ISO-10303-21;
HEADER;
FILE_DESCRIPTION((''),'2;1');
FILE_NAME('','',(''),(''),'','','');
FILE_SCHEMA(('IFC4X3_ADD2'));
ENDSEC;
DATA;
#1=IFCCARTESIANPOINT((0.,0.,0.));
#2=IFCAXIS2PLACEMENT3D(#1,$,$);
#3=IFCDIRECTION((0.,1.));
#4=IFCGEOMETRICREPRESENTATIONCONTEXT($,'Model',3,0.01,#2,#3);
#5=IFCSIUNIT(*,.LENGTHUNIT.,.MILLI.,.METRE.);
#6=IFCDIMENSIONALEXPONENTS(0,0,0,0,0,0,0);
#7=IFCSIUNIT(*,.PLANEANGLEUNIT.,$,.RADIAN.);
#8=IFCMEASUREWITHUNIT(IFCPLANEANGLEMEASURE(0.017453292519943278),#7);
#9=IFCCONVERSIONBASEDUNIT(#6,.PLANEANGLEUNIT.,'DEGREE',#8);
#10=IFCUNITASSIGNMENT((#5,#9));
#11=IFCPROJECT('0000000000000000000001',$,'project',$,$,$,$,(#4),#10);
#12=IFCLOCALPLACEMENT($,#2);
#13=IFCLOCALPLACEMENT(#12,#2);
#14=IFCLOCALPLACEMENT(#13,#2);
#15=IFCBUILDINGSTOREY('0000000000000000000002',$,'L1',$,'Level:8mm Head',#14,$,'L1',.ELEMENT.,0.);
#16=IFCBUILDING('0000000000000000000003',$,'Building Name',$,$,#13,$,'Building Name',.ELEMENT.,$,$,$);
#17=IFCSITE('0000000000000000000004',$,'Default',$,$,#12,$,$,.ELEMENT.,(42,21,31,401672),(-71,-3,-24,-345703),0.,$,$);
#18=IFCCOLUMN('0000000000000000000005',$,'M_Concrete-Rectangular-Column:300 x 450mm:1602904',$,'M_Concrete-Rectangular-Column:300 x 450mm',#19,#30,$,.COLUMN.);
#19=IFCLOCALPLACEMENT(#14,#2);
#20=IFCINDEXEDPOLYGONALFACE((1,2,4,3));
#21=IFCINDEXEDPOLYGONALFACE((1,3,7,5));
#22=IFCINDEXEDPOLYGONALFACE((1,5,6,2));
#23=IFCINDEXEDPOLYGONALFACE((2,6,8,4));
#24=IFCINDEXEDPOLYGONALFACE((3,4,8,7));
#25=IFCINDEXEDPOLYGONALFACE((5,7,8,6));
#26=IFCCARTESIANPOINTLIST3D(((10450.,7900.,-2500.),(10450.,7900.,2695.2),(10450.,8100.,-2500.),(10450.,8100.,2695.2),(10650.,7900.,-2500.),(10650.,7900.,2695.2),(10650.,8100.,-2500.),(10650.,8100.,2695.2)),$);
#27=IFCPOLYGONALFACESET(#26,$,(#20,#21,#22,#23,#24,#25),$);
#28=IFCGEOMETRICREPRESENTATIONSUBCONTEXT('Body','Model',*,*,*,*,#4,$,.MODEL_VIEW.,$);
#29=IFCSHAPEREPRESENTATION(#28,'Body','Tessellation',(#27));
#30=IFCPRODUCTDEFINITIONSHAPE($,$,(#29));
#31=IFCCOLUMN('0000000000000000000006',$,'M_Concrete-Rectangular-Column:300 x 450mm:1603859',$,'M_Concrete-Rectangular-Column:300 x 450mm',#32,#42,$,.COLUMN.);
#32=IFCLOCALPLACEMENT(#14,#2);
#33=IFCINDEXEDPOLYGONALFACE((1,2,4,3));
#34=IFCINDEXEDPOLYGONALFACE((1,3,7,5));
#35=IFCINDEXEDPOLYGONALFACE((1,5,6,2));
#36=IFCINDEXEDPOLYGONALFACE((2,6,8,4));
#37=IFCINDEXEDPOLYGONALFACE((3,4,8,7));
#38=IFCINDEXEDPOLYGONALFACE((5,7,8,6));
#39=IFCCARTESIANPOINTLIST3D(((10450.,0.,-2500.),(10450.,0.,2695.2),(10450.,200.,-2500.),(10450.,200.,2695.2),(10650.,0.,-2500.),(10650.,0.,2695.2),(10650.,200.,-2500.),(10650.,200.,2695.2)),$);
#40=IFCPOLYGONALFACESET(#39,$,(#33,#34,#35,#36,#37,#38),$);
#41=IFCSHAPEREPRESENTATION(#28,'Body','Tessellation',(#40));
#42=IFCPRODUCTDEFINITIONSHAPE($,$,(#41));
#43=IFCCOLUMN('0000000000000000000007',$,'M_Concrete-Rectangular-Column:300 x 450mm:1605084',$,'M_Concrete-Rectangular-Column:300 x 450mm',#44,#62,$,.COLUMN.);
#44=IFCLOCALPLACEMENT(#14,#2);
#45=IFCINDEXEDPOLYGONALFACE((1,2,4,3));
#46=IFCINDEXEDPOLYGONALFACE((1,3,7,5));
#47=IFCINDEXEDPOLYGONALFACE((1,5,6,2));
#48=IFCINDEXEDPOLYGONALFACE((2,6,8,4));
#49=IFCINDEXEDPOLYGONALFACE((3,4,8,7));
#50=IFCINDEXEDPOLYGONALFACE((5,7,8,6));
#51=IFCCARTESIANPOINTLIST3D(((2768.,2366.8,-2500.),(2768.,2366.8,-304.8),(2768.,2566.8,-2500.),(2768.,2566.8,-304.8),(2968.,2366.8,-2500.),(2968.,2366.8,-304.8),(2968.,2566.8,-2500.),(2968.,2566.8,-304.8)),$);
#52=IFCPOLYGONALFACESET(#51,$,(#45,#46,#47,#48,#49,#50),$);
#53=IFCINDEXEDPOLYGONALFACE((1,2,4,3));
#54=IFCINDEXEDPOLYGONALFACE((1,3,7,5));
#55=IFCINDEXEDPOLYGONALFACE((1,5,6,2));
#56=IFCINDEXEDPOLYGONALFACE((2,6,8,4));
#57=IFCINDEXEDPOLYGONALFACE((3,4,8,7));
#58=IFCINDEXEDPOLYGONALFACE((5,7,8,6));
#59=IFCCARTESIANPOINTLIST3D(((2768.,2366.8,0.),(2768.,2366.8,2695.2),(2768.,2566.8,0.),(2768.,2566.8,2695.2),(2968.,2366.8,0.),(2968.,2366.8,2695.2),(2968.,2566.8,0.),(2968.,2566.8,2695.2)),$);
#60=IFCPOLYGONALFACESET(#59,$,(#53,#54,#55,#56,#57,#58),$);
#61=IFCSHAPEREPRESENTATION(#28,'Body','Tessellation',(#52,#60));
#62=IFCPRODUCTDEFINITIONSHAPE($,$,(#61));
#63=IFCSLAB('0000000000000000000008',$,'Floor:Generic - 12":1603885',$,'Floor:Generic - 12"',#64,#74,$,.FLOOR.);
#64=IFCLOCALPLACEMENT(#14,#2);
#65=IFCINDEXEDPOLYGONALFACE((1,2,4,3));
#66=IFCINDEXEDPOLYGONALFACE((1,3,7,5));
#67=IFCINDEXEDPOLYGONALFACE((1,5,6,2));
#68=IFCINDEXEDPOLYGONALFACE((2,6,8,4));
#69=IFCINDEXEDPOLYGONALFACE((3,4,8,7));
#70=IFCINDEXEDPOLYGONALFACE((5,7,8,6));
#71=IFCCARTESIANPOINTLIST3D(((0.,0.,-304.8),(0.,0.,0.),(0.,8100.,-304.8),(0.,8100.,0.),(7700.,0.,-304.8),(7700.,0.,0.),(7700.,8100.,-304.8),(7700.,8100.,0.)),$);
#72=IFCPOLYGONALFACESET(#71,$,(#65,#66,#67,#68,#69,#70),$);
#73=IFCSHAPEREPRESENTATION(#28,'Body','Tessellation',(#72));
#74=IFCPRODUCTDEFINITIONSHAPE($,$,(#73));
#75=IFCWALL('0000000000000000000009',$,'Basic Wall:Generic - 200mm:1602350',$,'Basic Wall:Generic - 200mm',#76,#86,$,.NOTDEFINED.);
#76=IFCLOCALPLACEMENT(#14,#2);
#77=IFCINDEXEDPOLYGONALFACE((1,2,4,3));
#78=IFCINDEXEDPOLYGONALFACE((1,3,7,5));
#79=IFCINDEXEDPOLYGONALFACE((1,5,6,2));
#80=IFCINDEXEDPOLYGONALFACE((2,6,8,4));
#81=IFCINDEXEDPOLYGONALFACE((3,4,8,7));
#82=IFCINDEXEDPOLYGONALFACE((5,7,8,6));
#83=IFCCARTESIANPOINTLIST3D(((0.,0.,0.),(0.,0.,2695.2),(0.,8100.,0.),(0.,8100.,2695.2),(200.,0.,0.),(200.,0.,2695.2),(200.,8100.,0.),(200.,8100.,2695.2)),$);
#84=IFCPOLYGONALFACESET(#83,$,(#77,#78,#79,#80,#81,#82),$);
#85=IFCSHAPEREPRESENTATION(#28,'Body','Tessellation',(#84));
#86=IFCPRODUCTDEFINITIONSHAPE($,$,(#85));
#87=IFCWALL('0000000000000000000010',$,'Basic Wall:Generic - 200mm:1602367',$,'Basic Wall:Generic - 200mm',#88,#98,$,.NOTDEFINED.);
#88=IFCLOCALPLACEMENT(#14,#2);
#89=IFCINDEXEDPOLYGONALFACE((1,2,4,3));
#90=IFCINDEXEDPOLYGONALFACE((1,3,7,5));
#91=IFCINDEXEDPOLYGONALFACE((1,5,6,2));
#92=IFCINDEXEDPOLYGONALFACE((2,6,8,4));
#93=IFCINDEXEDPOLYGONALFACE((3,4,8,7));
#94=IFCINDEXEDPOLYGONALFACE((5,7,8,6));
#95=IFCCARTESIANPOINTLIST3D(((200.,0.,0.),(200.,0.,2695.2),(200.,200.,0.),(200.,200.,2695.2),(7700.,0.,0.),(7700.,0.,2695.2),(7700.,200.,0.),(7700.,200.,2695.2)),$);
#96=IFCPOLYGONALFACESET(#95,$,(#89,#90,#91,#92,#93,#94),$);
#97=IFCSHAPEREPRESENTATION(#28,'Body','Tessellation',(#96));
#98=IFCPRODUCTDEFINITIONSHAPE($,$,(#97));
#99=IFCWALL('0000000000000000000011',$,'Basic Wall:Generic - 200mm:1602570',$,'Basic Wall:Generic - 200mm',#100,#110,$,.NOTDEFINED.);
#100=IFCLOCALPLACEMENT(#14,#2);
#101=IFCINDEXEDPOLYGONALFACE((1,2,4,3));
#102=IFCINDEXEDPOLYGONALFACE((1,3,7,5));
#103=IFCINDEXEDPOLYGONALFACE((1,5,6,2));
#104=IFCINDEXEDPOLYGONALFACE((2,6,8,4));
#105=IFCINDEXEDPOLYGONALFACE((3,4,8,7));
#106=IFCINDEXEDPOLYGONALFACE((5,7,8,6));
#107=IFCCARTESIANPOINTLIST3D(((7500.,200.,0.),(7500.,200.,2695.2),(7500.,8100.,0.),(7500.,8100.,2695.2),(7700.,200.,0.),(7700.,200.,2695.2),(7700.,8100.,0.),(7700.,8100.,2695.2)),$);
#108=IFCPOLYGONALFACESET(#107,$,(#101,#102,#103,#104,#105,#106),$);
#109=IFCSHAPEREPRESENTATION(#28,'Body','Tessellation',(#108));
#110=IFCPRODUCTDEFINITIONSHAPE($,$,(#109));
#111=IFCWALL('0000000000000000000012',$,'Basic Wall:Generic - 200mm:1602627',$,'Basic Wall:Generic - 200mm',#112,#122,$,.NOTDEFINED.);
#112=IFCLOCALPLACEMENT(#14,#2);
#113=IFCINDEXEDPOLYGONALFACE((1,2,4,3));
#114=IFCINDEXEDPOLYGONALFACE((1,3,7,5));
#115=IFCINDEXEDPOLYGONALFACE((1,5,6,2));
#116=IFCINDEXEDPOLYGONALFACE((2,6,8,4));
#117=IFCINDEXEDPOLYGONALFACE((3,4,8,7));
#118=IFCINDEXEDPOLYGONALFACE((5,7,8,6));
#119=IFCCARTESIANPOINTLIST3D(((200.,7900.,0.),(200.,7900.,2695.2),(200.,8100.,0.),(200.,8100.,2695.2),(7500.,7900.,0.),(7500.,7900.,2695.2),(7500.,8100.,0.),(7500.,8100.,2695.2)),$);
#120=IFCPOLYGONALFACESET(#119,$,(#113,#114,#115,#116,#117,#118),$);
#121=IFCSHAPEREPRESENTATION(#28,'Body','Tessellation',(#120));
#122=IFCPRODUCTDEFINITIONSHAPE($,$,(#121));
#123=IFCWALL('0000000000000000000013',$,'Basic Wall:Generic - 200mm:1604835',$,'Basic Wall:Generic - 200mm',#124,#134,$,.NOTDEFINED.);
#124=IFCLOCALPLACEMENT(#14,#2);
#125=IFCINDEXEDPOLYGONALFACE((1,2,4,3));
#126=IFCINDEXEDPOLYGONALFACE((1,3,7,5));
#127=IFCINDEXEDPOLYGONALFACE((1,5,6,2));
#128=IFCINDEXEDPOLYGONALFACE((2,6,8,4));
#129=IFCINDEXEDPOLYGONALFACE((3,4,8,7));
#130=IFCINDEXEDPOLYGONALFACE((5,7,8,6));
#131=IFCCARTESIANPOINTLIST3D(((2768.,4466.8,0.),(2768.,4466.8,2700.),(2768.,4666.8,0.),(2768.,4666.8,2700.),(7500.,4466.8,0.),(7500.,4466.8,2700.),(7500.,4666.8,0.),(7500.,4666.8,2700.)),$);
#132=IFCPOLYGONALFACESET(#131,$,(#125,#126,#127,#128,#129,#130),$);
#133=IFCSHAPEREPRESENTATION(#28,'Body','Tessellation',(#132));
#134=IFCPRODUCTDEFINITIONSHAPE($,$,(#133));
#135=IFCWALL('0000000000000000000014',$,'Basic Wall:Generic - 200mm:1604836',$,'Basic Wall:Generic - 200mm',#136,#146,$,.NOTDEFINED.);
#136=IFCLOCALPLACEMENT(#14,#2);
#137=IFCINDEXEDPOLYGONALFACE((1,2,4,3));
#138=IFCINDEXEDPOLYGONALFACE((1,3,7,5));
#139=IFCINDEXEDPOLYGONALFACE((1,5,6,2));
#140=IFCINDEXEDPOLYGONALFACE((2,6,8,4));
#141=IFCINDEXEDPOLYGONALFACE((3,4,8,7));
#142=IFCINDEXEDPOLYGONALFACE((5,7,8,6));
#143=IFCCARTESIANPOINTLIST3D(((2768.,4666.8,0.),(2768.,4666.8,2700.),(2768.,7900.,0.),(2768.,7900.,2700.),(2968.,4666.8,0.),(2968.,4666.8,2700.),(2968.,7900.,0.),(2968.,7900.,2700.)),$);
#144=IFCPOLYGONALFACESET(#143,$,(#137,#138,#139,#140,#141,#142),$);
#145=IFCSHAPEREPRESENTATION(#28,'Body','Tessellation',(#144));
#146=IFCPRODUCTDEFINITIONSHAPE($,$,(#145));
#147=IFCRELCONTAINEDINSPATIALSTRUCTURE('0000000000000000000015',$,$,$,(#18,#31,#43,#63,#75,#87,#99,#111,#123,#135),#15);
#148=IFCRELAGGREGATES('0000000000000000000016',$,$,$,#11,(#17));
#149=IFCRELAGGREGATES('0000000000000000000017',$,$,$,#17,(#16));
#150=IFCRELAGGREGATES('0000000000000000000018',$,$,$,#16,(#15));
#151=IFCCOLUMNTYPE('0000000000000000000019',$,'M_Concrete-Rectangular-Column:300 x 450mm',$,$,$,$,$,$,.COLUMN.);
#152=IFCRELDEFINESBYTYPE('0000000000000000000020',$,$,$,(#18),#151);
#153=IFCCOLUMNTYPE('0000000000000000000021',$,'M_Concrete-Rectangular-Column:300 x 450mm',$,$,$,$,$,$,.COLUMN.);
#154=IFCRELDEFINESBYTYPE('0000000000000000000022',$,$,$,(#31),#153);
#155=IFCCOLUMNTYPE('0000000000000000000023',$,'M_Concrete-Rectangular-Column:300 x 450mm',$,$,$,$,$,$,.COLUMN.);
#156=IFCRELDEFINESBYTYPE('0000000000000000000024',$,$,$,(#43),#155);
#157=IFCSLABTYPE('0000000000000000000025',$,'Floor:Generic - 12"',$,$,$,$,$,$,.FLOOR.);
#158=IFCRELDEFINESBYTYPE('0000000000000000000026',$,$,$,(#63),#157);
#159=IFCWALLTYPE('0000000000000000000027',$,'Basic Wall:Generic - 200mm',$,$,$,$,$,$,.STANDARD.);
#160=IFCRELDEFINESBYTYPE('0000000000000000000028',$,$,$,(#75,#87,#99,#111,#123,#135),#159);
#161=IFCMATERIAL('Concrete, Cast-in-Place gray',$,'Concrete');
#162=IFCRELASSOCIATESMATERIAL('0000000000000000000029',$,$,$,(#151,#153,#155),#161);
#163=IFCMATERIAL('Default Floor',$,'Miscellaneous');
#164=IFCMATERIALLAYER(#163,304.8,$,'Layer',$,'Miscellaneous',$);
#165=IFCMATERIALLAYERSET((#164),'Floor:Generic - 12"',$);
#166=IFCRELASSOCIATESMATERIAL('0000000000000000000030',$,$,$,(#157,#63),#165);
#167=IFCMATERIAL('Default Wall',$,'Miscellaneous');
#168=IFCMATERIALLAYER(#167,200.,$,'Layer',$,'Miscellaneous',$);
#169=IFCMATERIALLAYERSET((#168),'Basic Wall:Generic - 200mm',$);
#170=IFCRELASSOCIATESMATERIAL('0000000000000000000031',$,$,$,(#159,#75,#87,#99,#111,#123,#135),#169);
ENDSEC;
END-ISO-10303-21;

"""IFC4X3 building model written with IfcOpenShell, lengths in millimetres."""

from ifc_helpers import new_model, entity, si_unit, converted_unit, direction, frame, frame_2d, origin, origin_2d_with_axis, place, context, subcontext, project, spatial, polyline, rectangle, extrude, clip, bounded_halfspace, source, transform, mapped, material, layer, layer_set, layer_usage, material_profile, profile_set, type_object, type_shapes, element, save


model = new_model("IFC4X3")

# Units and contexts
model_context = context("Model", 3, precision=0.01, world=origin(), true_north=direction((0.0, 1.0)))
body_context = subcontext(model_context, "Body", "Model", "MODEL_VIEW")
ifc_project = project(units=[si_unit("LENGTHUNIT", "METRE", prefix="MILLI"), converted_unit("PLANEANGLEUNIT", "DEGREE", entity("IfcPlaneAngleMeasure", 0.017453292519943278), si_unit("PLANEANGLEUNIT", "RADIAN"), dimensions=[0, 0, 0, 0, 0, 0, 0])], contexts=[model_context])

# Site, building, storey
site_placement = place(None, origin())
site = spatial("IfcSite", under=ifc_project, at=site_placement, Name="Default", CompositionType="ELEMENT", RefLatitude=(42, 21, 31, 401672), RefLongitude=(-71, -3, -24, -345703), RefElevation=0.0)
building_placement = place(site_placement, origin())
building = spatial("IfcBuilding", under=site, at=building_placement, Name="Building Name", LongName="Building Name", CompositionType="ELEMENT")
storey_placement = place(building_placement, origin())
storey = spatial("IfcBuildingStorey", under=building, at=storey_placement, Name="L1", ObjectType="Level:8mm Head", LongName="L1", CompositionType="ELEMENT", Elevation=0.0)

# Columns
ifc_material_1 = material(Name="Concrete, Cast-in-Place gray", Category="Concrete")
ifc_material_profile = material_profile(ifc_material_1, rectangle(XDim=200.0, YDim=200.0, at=frame_2d((0.0, 0.0), x_axis=(1.0, 0.0))), Name="300 x 450mm")
ifc_profile_set = profile_set([ifc_material_profile], Name="300 x 450mm")
column_type_1 = type_object("IfcColumnType", Name="M_Concrete-Rectangular-Column:300 x 450mm", PredefinedType="COLUMN", material=ifc_profile_set)
shared_shape_1 = source(origin(), body_context, "Body", "SweptSolid", [
    extrude(rectangle(XDim=200.0, YDim=200.0, at=frame_2d((0.0, 0.0), x_axis=(1.0, 0.0))), frame((10550.0, 8000.0, -2500.0), z_axis=(0.0, 0.0, 1.0), x_axis=(-1.0, 0.0, 0.0)), (0.0, 0.0, 1.0), 5195.2),
])
type_shapes(column_type_1, [shared_shape_1])
column_1_placement = place(storey_placement, origin())
element("IfcColumn", 1, at=column_1_placement, inside=storey, type_object=column_type_1, Name="M_Concrete-Rectangular-Column:300 x 450mm:1602904", ObjectType="M_Concrete-Rectangular-Column:300 x 450mm", PredefinedType="COLUMN", context=body_context, shape_type="MappedRepresentation", body=[
    mapped(shared_shape_1, transform((0.0, 0.0, 0.0), scale=1.0)),
])
column_type_2 = type_object("IfcColumnType", Name="M_Concrete-Rectangular-Column:300 x 450mm", PredefinedType="COLUMN", material=ifc_profile_set)
shared_shape_2 = source(origin(), body_context, "Body", "SweptSolid", [
    extrude(rectangle(XDim=200.0, YDim=200.0, at=frame_2d((0.0, 0.0), x_axis=(1.0, 0.0))), frame((10550.0, 100.0, -2500.0), z_axis=(0.0, 0.0, 1.0), x_axis=(-1.0, 0.0, 0.0)), (0.0, 0.0, 1.0), 5195.2),
])
type_shapes(column_type_2, [shared_shape_2])
column_2_placement = place(storey_placement, origin())
element("IfcColumn", 2, at=column_2_placement, inside=storey, type_object=column_type_2, Name="M_Concrete-Rectangular-Column:300 x 450mm:1603859", ObjectType="M_Concrete-Rectangular-Column:300 x 450mm", PredefinedType="COLUMN", context=body_context, shape_type="MappedRepresentation", body=[
    mapped(shared_shape_2, transform((0.0, 0.0, 0.0), scale=1.0)),
])
column_type_3 = type_object("IfcColumnType", Name="M_Concrete-Rectangular-Column:300 x 450mm", PredefinedType="COLUMN", material=ifc_profile_set)
shared_shape_3 = source(origin(), body_context, "Body", "SweptSolid", [
    extrude(rectangle(XDim=200.0, YDim=200.0, at=origin_2d_with_axis()), frame((2868.0, 2466.8, -2500.0), z_axis=(0.0, 0.0, 1.0), x_axis=(-1.0, 0.0, 0.0)), (0.0, 0.0, 1.0), 2195.2),
    extrude(rectangle(XDim=200.0, YDim=200.0, at=origin_2d_with_axis()), frame((2868.0, 2466.8, 0.0), z_axis=(0.0, 0.0, 1.0), x_axis=(-1.0, 0.0, 0.0)), (0.0, 0.0, 1.0), 2695.2),
])
type_shapes(column_type_3, [shared_shape_3])
column_3_placement = place(storey_placement, origin())
element("IfcColumn", 3, at=column_3_placement, inside=storey, type_object=column_type_3, Name="M_Concrete-Rectangular-Column:300 x 450mm:1605084", ObjectType="M_Concrete-Rectangular-Column:300 x 450mm", PredefinedType="COLUMN", context=body_context, shape_type="MappedRepresentation", body=[
    mapped(shared_shape_3, transform((0.0, 0.0, 0.0), scale=1.0)),
])

# Slab
ifc_material_2 = material(Name="Default Floor", Category="Miscellaneous")
ifc_layer_1 = layer(ifc_material_2, 304.8, Name="Layer", Category="Miscellaneous")
ifc_layer_set_1 = layer_set([ifc_layer_1], Name="Floor:Generic - 12\"")
ifc_layer_usage = layer_usage(ifc_layer_set_1, "AXIS3", "POSITIVE", 0.0)
slab_type = type_object("IfcSlabType", Name="Floor:Generic - 12\"", PredefinedType="FLOOR", material=ifc_layer_set_1)
slab_placement = place(storey_placement, origin())
element("IfcSlab", 4, at=slab_placement, inside=storey, type_object=slab_type, material=ifc_layer_usage, Name="Floor:Generic - 12\":1603885", ObjectType="Floor:Generic - 12\"", PredefinedType="FLOOR", context=body_context, shape_type="SweptSolid", body=[
    extrude(rectangle(XDim=8100.0, YDim=7700.0, at=origin_2d_with_axis()), frame((3850.0, 4050.0, 0.0), z_axis=(0.0, 0.0, -1.0), x_axis=(0.0, 1.0, 0.0)), (0.0, 0.0, 1.0), 304.8),
])

# Walls
ifc_material_3 = material(Name="Default Wall", Category="Miscellaneous")
ifc_layer_2 = layer(ifc_material_3, 200.0, Name="Layer", Category="Miscellaneous")
ifc_layer_set_2 = layer_set([ifc_layer_2], Name="Basic Wall:Generic - 200mm")
wall_type = type_object("IfcWallType", Name="Basic Wall:Generic - 200mm", PredefinedType="STANDARD", material=ifc_layer_set_2)
wall_1_placement = place(storey_placement, frame((100.0, 8100.0, 0.0), z_axis=(0.0, 0.0, 1.0), x_axis=(0.0, -1.0, 0.0)))
element("IfcWall", 5, at=wall_1_placement, inside=storey, type_object=wall_type, material=ifc_layer_set_2, Name="Basic Wall:Generic - 200mm:1602350", ObjectType="Basic Wall:Generic - 200mm", PredefinedType="NOTDEFINED", context=body_context, shape_type="Clipping", body=[
    clip(extrude(rectangle(XDim=8100.0, YDim=200.0, at=frame_2d((4050.0, 0.0), x_axis=(-1.0, 0.0))), origin(), (0.0, 0.0, 1.0), 2695.2), bounded_halfspace(frame((0.0, -100.0, 2695.2), z_axis=(0.0, 0.0, -1.0), x_axis=(0.0, 1.0, 0.0)), True, frame((0.0, -100.0, 2695.2)), polyline([(0.0, 0.0), (8100.0, 0.0), (8100.0, 200.0), (7900.0, 200.0), (200.0, 200.0), (0.0, 200.0), (0.0, 0.0)]))),
])
wall_2_placement = place(storey_placement, frame((200.0, 100.0, 0.0)))
element("IfcWall", 6, at=wall_2_placement, inside=storey, type_object=wall_type, material=ifc_layer_set_2, Name="Basic Wall:Generic - 200mm:1602367", ObjectType="Basic Wall:Generic - 200mm", PredefinedType="NOTDEFINED", context=body_context, shape_type="Clipping", body=[
    clip(extrude(rectangle(XDim=7500.0, YDim=200.0, at=frame_2d((3750.0, 0.0), x_axis=(-1.0, 0.0))), origin(), (0.0, 0.0, 1.0), 2695.2), bounded_halfspace(frame((0.0, -100.0, 2695.2), z_axis=(0.0, 0.0, -1.0), x_axis=(1.0, 0.0, 0.0)), True, frame((0.0, -100.0, 2695.2)), polyline([(0.0, 0.0), (7500.0, 0.0), (7500.0, 200.0), (7300.0, 200.0), (0.0, 200.0), (0.0, 0.0)]))),
])
wall_3_placement = place(storey_placement, frame((7600.0, 200.0, 0.0), z_axis=(0.0, 0.0, 1.0), x_axis=(0.0, 1.0, 0.0)))
element("IfcWall", 7, at=wall_3_placement, inside=storey, type_object=wall_type, material=ifc_layer_set_2, Name="Basic Wall:Generic - 200mm:1602570", ObjectType="Basic Wall:Generic - 200mm", PredefinedType="NOTDEFINED", context=body_context, shape_type="Clipping", body=[
    clip(extrude(rectangle(XDim=7900.0, YDim=200.0, at=frame_2d((3950.0, 0.0), x_axis=(-1.0, 0.0))), origin(), (0.0, 0.0, 1.0), 2695.2), bounded_halfspace(frame((0.0, -100.0, 2695.2), z_axis=(0.0, 0.0, -1.0), x_axis=(0.0, -1.0, 0.0)), True, frame((0.0, -100.0, 2695.2)), polyline([(0.0, 0.0), (7900.0, 0.0), (7900.0, 200.0), (7700.0, 200.0), (0.0, 200.0), (0.0, 0.0)]))),
])
wall_4_placement = place(storey_placement, frame((7500.0, 8000.0, 0.0), z_axis=(0.0, 0.0, 1.0), x_axis=(-1.0, 0.0, 0.0)))
element("IfcWall", 8, at=wall_4_placement, inside=storey, type_object=wall_type, material=ifc_layer_set_2, Name="Basic Wall:Generic - 200mm:1602627", ObjectType="Basic Wall:Generic - 200mm", PredefinedType="NOTDEFINED", context=body_context, shape_type="Clipping", body=[
    clip(extrude(rectangle(XDim=7300.0, YDim=200.0, at=frame_2d((3650.0, 0.0), x_axis=(-1.0, 0.0))), origin(), (0.0, 0.0, 1.0), 2695.2), bounded_halfspace(frame((0.0, -100.0, 2695.2), z_axis=(0.0, 0.0, -1.0), x_axis=(-1.0, 0.0, 0.0)), True, frame((0.0, -100.0, 2695.2)), polyline([(0.0, 0.0), (7300.0, 0.0), (7300.0, 200.0), (0.0, 200.0), (0.0, 0.0)]))),
])
wall_5_placement = place(storey_placement, frame((7500.0, 4566.8, 0.0), z_axis=(0.0, 0.0, 1.0), x_axis=(-1.0, 0.0, 0.0)))
element("IfcWall", 9, at=wall_5_placement, inside=storey, type_object=wall_type, material=ifc_layer_set_2, Name="Basic Wall:Generic - 200mm:1604835", ObjectType="Basic Wall:Generic - 200mm", PredefinedType="NOTDEFINED", context=body_context, shape_type="SweptSolid", body=[
    extrude(rectangle(XDim=4732.0, YDim=200.0, at=frame_2d((2366.0, 0.0), x_axis=(-1.0, 0.0))), origin(), (0.0, 0.0, 1.0), 2700.0),
])
wall_6_placement = place(storey_placement, frame((2868.0, 4666.8, 0.0), z_axis=(0.0, 0.0, 1.0), x_axis=(0.0, 1.0, 0.0)))
element("IfcWall", 10, at=wall_6_placement, inside=storey, type_object=wall_type, material=ifc_layer_set_2, Name="Basic Wall:Generic - 200mm:1604836", ObjectType="Basic Wall:Generic - 200mm", PredefinedType="NOTDEFINED", context=body_context, shape_type="SweptSolid", body=[
    extrude(rectangle(XDim=3233.2, YDim=200.0, at=frame_2d((1616.6, 0.0), x_axis=(-1.0, 0.0))), origin(), (0.0, 0.0, 1.0), 2700.0),
])

save(model, "model.ifc")
